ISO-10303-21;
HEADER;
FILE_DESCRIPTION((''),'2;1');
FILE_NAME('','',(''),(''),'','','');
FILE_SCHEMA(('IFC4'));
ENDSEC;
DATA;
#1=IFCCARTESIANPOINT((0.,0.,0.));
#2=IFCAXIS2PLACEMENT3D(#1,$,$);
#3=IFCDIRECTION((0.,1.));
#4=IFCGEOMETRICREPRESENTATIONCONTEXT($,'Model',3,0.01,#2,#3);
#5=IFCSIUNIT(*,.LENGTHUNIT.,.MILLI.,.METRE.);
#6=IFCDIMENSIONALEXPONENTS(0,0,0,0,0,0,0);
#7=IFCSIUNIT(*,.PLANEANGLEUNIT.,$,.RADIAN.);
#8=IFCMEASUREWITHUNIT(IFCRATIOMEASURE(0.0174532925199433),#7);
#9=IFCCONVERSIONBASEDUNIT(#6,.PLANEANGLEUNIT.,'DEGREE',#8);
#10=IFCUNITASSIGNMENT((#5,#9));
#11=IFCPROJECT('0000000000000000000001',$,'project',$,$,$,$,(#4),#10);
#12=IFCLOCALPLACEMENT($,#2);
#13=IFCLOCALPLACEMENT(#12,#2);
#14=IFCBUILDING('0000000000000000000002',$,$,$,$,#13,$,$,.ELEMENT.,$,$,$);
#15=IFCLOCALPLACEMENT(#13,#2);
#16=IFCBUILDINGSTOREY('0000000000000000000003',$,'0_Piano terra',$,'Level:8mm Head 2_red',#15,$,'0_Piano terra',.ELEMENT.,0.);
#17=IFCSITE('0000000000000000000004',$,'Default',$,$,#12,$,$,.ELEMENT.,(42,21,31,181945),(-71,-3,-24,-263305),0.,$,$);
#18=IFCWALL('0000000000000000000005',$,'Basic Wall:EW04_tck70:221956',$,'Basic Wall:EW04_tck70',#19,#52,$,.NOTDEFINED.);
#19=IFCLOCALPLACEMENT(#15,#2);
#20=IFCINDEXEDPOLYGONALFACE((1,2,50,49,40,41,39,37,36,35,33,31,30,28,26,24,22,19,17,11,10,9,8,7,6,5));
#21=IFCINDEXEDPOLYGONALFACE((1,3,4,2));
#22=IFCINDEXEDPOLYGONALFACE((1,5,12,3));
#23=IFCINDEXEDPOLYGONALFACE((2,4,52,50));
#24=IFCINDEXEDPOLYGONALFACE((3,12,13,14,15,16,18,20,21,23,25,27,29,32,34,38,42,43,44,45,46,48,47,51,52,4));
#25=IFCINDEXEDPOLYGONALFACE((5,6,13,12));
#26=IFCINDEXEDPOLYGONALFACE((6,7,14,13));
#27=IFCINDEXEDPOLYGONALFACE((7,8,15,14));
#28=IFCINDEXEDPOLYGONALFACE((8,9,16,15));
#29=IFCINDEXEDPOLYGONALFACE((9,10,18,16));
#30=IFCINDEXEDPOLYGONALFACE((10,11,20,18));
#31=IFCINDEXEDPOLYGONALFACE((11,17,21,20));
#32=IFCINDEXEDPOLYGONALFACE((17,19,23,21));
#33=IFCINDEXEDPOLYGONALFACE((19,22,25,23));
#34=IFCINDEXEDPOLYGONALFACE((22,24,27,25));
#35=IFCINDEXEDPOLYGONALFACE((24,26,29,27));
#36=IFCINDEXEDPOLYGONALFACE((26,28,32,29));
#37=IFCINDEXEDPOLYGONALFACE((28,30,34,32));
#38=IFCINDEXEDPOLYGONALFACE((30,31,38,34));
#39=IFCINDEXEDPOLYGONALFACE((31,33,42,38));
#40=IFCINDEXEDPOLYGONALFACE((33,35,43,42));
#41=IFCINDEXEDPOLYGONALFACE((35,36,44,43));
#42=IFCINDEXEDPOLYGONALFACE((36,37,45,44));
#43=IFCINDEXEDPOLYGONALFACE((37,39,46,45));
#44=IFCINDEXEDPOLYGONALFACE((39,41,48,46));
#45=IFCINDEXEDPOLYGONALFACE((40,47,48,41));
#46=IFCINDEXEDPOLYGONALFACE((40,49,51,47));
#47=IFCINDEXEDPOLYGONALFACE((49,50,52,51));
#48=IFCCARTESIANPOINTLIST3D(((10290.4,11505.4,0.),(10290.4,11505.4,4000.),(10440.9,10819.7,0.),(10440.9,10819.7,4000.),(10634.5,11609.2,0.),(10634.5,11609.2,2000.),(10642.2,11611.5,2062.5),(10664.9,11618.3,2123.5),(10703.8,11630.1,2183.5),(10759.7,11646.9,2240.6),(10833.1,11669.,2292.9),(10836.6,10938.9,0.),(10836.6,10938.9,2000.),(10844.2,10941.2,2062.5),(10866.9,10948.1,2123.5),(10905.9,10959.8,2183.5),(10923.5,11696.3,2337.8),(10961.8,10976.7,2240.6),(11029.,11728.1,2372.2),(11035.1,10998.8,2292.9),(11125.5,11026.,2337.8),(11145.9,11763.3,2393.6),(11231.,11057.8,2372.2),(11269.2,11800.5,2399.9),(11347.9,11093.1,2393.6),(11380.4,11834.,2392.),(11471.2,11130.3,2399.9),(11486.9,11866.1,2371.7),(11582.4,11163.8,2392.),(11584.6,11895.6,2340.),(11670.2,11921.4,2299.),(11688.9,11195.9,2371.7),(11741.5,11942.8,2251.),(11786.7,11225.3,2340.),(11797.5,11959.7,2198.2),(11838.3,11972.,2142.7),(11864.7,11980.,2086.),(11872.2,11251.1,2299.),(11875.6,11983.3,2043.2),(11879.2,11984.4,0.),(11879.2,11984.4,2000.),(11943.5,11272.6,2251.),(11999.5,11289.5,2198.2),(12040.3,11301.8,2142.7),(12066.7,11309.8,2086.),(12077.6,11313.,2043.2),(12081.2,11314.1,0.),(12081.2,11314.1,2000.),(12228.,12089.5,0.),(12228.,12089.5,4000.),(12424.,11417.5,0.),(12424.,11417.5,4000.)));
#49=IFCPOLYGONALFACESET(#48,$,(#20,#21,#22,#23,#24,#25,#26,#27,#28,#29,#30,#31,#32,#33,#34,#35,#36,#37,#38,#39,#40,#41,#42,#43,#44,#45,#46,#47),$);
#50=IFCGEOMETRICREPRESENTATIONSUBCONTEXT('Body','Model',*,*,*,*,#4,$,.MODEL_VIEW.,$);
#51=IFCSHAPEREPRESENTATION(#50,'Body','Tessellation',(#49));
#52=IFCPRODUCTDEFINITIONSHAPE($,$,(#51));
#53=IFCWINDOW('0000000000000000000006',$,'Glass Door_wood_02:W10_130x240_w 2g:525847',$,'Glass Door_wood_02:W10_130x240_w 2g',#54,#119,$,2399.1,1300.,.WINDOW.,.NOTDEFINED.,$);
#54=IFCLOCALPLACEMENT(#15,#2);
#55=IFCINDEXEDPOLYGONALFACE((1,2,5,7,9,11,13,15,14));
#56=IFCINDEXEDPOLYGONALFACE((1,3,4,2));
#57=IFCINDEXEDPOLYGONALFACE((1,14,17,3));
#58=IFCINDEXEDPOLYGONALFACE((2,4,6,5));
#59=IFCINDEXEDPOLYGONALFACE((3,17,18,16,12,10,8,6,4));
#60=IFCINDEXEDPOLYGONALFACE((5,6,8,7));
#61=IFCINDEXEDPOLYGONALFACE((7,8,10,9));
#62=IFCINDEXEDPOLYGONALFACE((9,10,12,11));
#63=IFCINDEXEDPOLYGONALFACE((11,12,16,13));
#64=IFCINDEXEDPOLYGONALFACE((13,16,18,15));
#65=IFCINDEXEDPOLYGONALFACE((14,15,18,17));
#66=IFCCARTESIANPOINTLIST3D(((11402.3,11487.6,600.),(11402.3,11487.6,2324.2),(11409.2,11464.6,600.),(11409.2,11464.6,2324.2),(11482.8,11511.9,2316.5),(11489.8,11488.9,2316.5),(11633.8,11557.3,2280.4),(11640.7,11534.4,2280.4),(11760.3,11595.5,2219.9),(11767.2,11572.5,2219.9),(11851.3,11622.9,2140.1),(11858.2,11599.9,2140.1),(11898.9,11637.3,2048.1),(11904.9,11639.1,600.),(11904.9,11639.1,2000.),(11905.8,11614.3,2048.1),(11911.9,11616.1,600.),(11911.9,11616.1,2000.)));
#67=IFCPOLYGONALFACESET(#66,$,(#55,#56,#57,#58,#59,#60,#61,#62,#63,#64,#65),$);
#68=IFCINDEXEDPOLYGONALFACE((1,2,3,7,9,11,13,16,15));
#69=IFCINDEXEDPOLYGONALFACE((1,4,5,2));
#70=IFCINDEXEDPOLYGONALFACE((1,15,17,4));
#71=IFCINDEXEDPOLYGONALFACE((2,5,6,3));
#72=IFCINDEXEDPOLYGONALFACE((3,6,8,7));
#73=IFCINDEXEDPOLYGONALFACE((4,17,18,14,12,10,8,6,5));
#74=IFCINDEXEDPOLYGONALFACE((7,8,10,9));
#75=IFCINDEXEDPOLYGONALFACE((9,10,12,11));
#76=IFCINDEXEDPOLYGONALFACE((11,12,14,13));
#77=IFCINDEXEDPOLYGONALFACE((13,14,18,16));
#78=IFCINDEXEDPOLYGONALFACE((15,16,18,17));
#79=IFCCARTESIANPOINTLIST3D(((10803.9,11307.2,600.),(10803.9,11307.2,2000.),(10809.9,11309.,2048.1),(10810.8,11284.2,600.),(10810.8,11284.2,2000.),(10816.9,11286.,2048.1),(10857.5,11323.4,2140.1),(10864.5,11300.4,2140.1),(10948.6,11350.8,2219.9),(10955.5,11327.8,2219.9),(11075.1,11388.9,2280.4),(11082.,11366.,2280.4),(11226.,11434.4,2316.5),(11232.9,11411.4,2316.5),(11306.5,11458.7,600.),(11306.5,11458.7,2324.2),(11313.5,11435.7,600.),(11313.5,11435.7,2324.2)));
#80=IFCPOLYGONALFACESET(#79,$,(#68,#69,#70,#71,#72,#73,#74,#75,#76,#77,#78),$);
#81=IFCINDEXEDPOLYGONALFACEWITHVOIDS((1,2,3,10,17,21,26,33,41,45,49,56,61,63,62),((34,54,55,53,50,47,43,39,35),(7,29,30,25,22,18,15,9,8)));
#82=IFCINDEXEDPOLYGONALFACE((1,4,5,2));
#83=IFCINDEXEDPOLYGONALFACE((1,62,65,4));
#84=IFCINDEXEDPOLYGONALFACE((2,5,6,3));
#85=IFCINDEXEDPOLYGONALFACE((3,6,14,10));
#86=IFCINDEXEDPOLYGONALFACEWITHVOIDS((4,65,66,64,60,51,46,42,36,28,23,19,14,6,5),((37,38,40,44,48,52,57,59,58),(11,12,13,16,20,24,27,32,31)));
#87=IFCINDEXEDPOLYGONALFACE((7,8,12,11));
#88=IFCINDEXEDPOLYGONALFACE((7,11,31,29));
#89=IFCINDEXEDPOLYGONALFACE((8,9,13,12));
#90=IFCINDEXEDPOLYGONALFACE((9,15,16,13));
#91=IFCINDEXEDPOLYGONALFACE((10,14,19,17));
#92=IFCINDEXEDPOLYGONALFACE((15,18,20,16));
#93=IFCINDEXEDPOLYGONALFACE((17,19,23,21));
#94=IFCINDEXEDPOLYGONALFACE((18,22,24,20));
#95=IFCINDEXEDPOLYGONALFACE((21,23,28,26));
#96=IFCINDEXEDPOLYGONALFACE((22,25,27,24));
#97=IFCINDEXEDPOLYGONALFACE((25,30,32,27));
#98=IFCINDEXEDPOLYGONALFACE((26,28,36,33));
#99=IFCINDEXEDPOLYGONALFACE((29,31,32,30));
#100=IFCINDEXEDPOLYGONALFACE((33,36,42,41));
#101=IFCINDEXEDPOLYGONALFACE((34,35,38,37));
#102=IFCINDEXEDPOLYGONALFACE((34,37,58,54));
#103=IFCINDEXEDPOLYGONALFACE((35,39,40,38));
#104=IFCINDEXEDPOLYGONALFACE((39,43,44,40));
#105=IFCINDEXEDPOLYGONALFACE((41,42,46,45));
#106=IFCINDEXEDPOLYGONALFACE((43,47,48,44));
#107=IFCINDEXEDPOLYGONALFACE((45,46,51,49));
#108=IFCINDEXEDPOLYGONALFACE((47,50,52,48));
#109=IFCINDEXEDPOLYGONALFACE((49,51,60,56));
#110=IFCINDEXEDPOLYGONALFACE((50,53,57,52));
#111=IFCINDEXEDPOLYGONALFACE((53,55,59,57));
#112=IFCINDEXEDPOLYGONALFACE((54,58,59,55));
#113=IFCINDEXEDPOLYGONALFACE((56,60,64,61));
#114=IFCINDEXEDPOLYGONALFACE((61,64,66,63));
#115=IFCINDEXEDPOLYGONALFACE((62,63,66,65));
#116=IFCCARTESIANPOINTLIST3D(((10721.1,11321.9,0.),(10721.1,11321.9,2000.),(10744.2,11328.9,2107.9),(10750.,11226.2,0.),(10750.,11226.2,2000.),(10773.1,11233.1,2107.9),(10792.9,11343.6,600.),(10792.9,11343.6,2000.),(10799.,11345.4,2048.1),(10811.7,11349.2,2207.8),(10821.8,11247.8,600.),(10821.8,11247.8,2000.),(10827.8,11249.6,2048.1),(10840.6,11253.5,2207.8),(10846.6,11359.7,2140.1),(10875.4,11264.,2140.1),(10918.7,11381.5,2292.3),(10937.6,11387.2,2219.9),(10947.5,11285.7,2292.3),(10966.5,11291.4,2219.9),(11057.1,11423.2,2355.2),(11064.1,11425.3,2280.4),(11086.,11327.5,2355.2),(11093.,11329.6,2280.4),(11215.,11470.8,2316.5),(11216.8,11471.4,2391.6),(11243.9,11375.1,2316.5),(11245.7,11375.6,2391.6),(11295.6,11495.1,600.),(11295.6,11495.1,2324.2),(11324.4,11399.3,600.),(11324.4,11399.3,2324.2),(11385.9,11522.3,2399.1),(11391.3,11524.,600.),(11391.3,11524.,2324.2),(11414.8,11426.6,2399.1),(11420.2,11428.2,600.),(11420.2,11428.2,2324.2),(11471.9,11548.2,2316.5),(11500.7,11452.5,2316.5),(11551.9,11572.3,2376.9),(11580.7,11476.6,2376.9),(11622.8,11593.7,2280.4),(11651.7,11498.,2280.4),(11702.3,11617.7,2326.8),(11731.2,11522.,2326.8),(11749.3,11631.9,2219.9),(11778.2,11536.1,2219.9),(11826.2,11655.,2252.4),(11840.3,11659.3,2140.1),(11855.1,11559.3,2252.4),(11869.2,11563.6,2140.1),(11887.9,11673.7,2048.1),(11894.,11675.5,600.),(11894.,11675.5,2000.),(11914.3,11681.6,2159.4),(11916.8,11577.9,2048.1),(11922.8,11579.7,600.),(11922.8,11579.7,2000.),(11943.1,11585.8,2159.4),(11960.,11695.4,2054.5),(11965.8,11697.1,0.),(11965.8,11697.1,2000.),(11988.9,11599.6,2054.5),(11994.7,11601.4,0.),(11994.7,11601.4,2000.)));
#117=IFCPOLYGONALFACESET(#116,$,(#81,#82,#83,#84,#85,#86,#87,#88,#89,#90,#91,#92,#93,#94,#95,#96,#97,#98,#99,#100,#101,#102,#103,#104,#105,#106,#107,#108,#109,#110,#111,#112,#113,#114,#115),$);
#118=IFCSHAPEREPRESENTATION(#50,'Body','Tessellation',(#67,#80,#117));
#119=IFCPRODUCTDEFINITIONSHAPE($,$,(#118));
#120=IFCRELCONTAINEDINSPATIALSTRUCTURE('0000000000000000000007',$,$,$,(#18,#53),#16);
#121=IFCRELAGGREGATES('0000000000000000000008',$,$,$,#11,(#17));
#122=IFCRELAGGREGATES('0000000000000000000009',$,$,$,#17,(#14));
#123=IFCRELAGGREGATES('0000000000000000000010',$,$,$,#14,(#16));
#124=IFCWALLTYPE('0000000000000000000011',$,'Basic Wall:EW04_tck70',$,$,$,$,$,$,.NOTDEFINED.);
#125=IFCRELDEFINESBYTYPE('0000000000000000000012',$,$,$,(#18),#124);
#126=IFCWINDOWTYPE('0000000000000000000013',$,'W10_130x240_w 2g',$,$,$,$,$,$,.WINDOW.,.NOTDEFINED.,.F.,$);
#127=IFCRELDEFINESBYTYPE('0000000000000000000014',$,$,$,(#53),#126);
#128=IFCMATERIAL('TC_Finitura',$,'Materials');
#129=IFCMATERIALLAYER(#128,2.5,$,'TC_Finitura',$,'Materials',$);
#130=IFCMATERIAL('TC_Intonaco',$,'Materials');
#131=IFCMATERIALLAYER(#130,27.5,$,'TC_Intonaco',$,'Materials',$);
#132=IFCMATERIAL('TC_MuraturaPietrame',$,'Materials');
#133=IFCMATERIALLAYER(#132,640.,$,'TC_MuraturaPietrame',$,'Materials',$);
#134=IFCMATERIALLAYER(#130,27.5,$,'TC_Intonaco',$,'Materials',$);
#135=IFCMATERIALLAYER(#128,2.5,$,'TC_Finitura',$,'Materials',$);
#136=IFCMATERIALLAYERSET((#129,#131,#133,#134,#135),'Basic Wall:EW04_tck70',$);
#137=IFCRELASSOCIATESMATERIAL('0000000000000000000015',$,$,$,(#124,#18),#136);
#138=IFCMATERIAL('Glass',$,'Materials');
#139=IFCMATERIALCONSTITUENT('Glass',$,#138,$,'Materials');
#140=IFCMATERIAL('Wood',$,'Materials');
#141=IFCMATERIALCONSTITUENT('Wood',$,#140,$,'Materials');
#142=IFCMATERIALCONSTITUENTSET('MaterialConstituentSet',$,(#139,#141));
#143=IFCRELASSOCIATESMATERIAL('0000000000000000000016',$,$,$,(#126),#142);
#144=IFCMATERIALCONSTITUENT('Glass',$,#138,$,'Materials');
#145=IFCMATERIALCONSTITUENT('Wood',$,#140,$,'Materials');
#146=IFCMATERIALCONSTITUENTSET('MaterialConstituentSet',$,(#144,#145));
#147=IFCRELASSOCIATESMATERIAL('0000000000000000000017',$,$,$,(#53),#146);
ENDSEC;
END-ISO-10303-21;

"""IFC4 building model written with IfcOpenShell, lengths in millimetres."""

from ifc_helpers import new_model, entity, si_unit, converted_unit, direction, frame, frame_2d, origin, place, context, subcontext, project, spatial, polyline, ellipse_curve, parameter, trimmed, segment, composite_curve, outline, extrude, clip, bounded_halfspace, source, transform, mapped, material, layer, layer_set, layer_usage, constituent, constituent_set, type_object, type_shapes, element, fill, save


model = new_model("IFC4")

# Units and contexts
model_context = context("Model", 3, precision=0.01, world=origin(), true_north=direction((0.0, 1.0)))
body_context = subcontext(model_context, "Body", "Model", "MODEL_VIEW")
ifc_project = project(units=[si_unit("LENGTHUNIT", "METRE", prefix="MILLI"), converted_unit("PLANEANGLEUNIT", "DEGREE", entity("IfcRatioMeasure", 0.0174532925199433), si_unit("PLANEANGLEUNIT", "RADIAN"), dimensions=[0, 0, 0, 0, 0, 0, 0])], contexts=[model_context])

# Site, building, storey
site_placement = place(None, origin())
site = spatial("IfcSite", under=ifc_project, at=site_placement, Name="Default", CompositionType="ELEMENT", RefLatitude=(42, 21, 31, 181945), RefLongitude=(-71, -3, -24, -263305), RefElevation=0.0)
building_placement = place(site_placement, origin())
building = spatial("IfcBuilding", under=site, at=building_placement, CompositionType="ELEMENT")
storey_placement = place(building_placement, origin())
storey = spatial("IfcBuildingStorey", under=building, at=storey_placement, Name="0_Piano terra", ObjectType="Level:8mm Head 2_red", LongName="0_Piano terra", CompositionType="ELEMENT", Elevation=0.0)

# Shared definitions
ifc_material_1 = material(Name="TC_Finitura", Category="Materials")
ifc_material_2 = material(Name="TC_Intonaco", Category="Materials")
ifc_material_3 = material(Name="TC_MuraturaPietrame", Category="Materials")

# Shared definitions
ifc_material_4 = material(Name="Glass", Category="Materials")

# Wall, opening, window
ifc_layer_1 = layer(ifc_material_1, 2.5, Name="TC_Finitura", Category="Materials")
ifc_layer_2 = layer(ifc_material_2, 27.5, Name="TC_Intonaco", Category="Materials")
ifc_layer_3 = layer(ifc_material_3, 640.0, Name="TC_MuraturaPietrame", Category="Materials")
ifc_layer_4 = layer(ifc_material_2, 27.5, Name="TC_Intonaco", Category="Materials")
ifc_layer_5 = layer(ifc_material_1, 2.5, Name="TC_Finitura", Category="Materials")
ifc_layer_set_1 = layer_set([ifc_layer_1, ifc_layer_2, ifc_layer_3, ifc_layer_4, ifc_layer_5], Name="Basic Wall:EW04_tck70")
ifc_layer_usage_1 = layer_usage(ifc_layer_set_1, "AXIS2", "NEGATIVE", 350.0)
wall_type_1 = type_object("IfcWallType", Name="Basic Wall:EW04_tck70", PredefinedType="NOTDEFINED", material=ifc_layer_set_1)
wall_1_placement = place(storey_placement, frame((12329.0, 11754.4, 0.0), z_axis=(0.0, 0.0, 1.0), x_axis=(-0.957445, -0.288616, 0.0)))
wall_1 = element("IfcWall", 1, at=wall_1_placement, inside=storey, type_object=wall_type_1, material=ifc_layer_usage_1, Name="Basic Wall:EW04_tck70:221956", ObjectType="Basic Wall:EW04_tck70", PredefinedType="NOTDEFINED", context=body_context, shape_type="Clipping", body=[
    clip(extrude(outline(polyline([(0.0, -350.0), (2023.8, -350.0), (2077.5, 350.0), (6.3, 350.0), (0.0, -350.0)])), origin(), (0.0, 0.0, 1.0), 4000.0), bounded_halfspace(frame((0.0, -350.0, 4000.0), z_axis=(0.0, 0.0, -1.0), x_axis=(0.014156, 0.9999, 0.0)), True, frame((0.0, -350.0, 4000.0)), polyline([(0.0, 0.0), (2023.8, 0.0), (2077.5, 700.0), (6.3, 700.0), (0.0, 0.0)]))),
])
opening_1_placement = place(wall_1_placement, frame((1664.3, 350.0, 0.0)))
opening_1 = element("IfcOpeningElement", 2, at=opening_1_placement, cuts=wall_1, ObjectType="Opening", PredefinedType="OPENING", context=body_context, shape_type="SweptSolid", body=[
    extrude(outline(composite_curve([segment(polyline([(0.0, 1300.0), (0.0, 0.0)]), True, "CONTINUOUS"), segment(polyline([(0.0, 0.0), (2000.0, 0.0)]), True, "CONTINUOUS"), segment(trimmed(ellipse_curve(frame_2d((2000.0, 650.0), x_axis=(0.0, 1.0)), 650.0, 400.0), [parameter(180.0)], [parameter(360.0)], True, "PARAMETER"), True, "CONTINUOUS"), segment(polyline([(2000.0, 1300.0), (0.0, 1300.0)]), True, "CONTINUOUS")], self_intersect=False)), frame((0.0, 0.0, 0.0), z_axis=(0.0, -1.0, 0.0), x_axis=(0.0, 0.0, 1.0)), (0.0, 0.0, 1.0), 700.0),
])
ifc_constituent_1 = constituent(ifc_material_4, Name="Glass", Category="Materials")
ifc_material_5 = material(Name="Wood", Category="Materials")
ifc_constituent_2 = constituent(ifc_material_5, Name="Wood", Category="Materials")
ifc_constituent_set_1 = constituent_set(constituents=[ifc_constituent_1, ifc_constituent_2], Name="MaterialConstituentSet")
ifc_constituent_3 = constituent(ifc_material_4, Name="Glass", Category="Materials")
ifc_constituent_4 = constituent(ifc_material_5, Name="Wood", Category="Materials")
ifc_constituent_set_2 = constituent_set(constituents=[ifc_constituent_3, ifc_constituent_4], Name="MaterialConstituentSet")
window_type_1 = type_object("IfcWindowType", Name="W10_130x240_w 2g", ParameterTakesPrecedence=False, PartitioningType="NOTDEFINED", PredefinedType="WINDOW", material=ifc_constituent_set_2)
shared_shape_1 = source(origin(), body_context, "Body", "SweptSolid", [
    extrude(outline(polyline([(-347.6, -457.7), (-263.1, -457.7), (-102.8, -436.3), (34.3, -388.1), (136.3, -317.4), (194.2, -230.3), (204.9, -183.0), (333.3, 1211.1), (-189.5, 1259.3), (-347.6, -457.7)])), frame((1004.2, 338.0, 1836.6), z_axis=(0.0, 1.0, 0.0), x_axis=(0.995788, 0.0, -0.091683)), (0.0, 0.0, 1.0), 24.0),
    extrude(outline(polyline([(133.3, -240.2), (181.8, -240.2), (279.5, -202.9), (371.0, -119.0), (448.2, 4.1), (504.5, 155.7), (523.1, 238.1), (-1186.5, 462.6), (-1254.8, -58.0), (133.3, -240.2)])), frame((295.8, 338.0, 1836.6), z_axis=(0.0, 1.0, 0.0), x_axis=(0.130191, 0.0, 0.991489)), (0.0, 0.0, 1.0), 24.0),
    extrude(outline(polyline([(-628.3, -1928.3), (671.7, -1928.3), (671.7, 71.7), (647.6, 179.7), (577.0, 279.6), (465.3, 364.1), (320.7, 426.9), (153.9, 463.4), (-22.7, 470.8), (-196.0, 448.6), (-353.2, 398.5), (-482.5, 324.2), (-574.5, 231.1), (-622.3, 126.2), (-628.3, 71.7), (-628.3, -1928.3)]), holes=[polyline([(-553.3, -1328.3), (-553.3, 71.7), (-547.0, 119.9), (-497.3, 211.9), (-402.2, 291.6), (-270.1, 352.2), (-112.5, 388.2), (-28.3, 396.0), (-28.3, -1328.3), (-553.3, -1328.3)]), polyline([(596.7, -1328.3), (71.7, -1328.3), (71.7, 396.0), (155.8, 388.2), (313.4, 352.2), (445.6, 291.6), (540.6, 211.9), (590.3, 119.9), (596.7, 71.7), (596.7, -1328.3)])]), frame((671.7, 300.0, 1928.3), z_axis=(0.0, 1.0, 0.0), x_axis=(-1.0, 0.0, 0.0)), (0.0, 0.0, 1.0), 100.0),
])
type_shapes(window_type_1, [shared_shape_1])
window_1_placement = place(opening_1_placement, frame((0.0, 0.0, 0.0), z_axis=(0.0, 0.0, 1.0), x_axis=(-1.0, 0.0, 0.0)))
window_1 = element("IfcWindow", 3, at=window_1_placement, inside=storey, type_object=window_type_1, material=ifc_constituent_set_1, Name="Glass Door_wood_02:W10_130x240_w 2g:525847", ObjectType="Glass Door_wood_02:W10_130x240_w 2g", OverallHeight=2399.1, OverallWidth=1300.0, PartitioningType="NOTDEFINED", PredefinedType="WINDOW", context=body_context, shape_type="MappedRepresentation", body=[
    mapped(shared_shape_1, transform((0.0, 0.0, 0.0), scale=1.0)),
])
fill(opening_1, window_1)

save(model, "model.ifc")
